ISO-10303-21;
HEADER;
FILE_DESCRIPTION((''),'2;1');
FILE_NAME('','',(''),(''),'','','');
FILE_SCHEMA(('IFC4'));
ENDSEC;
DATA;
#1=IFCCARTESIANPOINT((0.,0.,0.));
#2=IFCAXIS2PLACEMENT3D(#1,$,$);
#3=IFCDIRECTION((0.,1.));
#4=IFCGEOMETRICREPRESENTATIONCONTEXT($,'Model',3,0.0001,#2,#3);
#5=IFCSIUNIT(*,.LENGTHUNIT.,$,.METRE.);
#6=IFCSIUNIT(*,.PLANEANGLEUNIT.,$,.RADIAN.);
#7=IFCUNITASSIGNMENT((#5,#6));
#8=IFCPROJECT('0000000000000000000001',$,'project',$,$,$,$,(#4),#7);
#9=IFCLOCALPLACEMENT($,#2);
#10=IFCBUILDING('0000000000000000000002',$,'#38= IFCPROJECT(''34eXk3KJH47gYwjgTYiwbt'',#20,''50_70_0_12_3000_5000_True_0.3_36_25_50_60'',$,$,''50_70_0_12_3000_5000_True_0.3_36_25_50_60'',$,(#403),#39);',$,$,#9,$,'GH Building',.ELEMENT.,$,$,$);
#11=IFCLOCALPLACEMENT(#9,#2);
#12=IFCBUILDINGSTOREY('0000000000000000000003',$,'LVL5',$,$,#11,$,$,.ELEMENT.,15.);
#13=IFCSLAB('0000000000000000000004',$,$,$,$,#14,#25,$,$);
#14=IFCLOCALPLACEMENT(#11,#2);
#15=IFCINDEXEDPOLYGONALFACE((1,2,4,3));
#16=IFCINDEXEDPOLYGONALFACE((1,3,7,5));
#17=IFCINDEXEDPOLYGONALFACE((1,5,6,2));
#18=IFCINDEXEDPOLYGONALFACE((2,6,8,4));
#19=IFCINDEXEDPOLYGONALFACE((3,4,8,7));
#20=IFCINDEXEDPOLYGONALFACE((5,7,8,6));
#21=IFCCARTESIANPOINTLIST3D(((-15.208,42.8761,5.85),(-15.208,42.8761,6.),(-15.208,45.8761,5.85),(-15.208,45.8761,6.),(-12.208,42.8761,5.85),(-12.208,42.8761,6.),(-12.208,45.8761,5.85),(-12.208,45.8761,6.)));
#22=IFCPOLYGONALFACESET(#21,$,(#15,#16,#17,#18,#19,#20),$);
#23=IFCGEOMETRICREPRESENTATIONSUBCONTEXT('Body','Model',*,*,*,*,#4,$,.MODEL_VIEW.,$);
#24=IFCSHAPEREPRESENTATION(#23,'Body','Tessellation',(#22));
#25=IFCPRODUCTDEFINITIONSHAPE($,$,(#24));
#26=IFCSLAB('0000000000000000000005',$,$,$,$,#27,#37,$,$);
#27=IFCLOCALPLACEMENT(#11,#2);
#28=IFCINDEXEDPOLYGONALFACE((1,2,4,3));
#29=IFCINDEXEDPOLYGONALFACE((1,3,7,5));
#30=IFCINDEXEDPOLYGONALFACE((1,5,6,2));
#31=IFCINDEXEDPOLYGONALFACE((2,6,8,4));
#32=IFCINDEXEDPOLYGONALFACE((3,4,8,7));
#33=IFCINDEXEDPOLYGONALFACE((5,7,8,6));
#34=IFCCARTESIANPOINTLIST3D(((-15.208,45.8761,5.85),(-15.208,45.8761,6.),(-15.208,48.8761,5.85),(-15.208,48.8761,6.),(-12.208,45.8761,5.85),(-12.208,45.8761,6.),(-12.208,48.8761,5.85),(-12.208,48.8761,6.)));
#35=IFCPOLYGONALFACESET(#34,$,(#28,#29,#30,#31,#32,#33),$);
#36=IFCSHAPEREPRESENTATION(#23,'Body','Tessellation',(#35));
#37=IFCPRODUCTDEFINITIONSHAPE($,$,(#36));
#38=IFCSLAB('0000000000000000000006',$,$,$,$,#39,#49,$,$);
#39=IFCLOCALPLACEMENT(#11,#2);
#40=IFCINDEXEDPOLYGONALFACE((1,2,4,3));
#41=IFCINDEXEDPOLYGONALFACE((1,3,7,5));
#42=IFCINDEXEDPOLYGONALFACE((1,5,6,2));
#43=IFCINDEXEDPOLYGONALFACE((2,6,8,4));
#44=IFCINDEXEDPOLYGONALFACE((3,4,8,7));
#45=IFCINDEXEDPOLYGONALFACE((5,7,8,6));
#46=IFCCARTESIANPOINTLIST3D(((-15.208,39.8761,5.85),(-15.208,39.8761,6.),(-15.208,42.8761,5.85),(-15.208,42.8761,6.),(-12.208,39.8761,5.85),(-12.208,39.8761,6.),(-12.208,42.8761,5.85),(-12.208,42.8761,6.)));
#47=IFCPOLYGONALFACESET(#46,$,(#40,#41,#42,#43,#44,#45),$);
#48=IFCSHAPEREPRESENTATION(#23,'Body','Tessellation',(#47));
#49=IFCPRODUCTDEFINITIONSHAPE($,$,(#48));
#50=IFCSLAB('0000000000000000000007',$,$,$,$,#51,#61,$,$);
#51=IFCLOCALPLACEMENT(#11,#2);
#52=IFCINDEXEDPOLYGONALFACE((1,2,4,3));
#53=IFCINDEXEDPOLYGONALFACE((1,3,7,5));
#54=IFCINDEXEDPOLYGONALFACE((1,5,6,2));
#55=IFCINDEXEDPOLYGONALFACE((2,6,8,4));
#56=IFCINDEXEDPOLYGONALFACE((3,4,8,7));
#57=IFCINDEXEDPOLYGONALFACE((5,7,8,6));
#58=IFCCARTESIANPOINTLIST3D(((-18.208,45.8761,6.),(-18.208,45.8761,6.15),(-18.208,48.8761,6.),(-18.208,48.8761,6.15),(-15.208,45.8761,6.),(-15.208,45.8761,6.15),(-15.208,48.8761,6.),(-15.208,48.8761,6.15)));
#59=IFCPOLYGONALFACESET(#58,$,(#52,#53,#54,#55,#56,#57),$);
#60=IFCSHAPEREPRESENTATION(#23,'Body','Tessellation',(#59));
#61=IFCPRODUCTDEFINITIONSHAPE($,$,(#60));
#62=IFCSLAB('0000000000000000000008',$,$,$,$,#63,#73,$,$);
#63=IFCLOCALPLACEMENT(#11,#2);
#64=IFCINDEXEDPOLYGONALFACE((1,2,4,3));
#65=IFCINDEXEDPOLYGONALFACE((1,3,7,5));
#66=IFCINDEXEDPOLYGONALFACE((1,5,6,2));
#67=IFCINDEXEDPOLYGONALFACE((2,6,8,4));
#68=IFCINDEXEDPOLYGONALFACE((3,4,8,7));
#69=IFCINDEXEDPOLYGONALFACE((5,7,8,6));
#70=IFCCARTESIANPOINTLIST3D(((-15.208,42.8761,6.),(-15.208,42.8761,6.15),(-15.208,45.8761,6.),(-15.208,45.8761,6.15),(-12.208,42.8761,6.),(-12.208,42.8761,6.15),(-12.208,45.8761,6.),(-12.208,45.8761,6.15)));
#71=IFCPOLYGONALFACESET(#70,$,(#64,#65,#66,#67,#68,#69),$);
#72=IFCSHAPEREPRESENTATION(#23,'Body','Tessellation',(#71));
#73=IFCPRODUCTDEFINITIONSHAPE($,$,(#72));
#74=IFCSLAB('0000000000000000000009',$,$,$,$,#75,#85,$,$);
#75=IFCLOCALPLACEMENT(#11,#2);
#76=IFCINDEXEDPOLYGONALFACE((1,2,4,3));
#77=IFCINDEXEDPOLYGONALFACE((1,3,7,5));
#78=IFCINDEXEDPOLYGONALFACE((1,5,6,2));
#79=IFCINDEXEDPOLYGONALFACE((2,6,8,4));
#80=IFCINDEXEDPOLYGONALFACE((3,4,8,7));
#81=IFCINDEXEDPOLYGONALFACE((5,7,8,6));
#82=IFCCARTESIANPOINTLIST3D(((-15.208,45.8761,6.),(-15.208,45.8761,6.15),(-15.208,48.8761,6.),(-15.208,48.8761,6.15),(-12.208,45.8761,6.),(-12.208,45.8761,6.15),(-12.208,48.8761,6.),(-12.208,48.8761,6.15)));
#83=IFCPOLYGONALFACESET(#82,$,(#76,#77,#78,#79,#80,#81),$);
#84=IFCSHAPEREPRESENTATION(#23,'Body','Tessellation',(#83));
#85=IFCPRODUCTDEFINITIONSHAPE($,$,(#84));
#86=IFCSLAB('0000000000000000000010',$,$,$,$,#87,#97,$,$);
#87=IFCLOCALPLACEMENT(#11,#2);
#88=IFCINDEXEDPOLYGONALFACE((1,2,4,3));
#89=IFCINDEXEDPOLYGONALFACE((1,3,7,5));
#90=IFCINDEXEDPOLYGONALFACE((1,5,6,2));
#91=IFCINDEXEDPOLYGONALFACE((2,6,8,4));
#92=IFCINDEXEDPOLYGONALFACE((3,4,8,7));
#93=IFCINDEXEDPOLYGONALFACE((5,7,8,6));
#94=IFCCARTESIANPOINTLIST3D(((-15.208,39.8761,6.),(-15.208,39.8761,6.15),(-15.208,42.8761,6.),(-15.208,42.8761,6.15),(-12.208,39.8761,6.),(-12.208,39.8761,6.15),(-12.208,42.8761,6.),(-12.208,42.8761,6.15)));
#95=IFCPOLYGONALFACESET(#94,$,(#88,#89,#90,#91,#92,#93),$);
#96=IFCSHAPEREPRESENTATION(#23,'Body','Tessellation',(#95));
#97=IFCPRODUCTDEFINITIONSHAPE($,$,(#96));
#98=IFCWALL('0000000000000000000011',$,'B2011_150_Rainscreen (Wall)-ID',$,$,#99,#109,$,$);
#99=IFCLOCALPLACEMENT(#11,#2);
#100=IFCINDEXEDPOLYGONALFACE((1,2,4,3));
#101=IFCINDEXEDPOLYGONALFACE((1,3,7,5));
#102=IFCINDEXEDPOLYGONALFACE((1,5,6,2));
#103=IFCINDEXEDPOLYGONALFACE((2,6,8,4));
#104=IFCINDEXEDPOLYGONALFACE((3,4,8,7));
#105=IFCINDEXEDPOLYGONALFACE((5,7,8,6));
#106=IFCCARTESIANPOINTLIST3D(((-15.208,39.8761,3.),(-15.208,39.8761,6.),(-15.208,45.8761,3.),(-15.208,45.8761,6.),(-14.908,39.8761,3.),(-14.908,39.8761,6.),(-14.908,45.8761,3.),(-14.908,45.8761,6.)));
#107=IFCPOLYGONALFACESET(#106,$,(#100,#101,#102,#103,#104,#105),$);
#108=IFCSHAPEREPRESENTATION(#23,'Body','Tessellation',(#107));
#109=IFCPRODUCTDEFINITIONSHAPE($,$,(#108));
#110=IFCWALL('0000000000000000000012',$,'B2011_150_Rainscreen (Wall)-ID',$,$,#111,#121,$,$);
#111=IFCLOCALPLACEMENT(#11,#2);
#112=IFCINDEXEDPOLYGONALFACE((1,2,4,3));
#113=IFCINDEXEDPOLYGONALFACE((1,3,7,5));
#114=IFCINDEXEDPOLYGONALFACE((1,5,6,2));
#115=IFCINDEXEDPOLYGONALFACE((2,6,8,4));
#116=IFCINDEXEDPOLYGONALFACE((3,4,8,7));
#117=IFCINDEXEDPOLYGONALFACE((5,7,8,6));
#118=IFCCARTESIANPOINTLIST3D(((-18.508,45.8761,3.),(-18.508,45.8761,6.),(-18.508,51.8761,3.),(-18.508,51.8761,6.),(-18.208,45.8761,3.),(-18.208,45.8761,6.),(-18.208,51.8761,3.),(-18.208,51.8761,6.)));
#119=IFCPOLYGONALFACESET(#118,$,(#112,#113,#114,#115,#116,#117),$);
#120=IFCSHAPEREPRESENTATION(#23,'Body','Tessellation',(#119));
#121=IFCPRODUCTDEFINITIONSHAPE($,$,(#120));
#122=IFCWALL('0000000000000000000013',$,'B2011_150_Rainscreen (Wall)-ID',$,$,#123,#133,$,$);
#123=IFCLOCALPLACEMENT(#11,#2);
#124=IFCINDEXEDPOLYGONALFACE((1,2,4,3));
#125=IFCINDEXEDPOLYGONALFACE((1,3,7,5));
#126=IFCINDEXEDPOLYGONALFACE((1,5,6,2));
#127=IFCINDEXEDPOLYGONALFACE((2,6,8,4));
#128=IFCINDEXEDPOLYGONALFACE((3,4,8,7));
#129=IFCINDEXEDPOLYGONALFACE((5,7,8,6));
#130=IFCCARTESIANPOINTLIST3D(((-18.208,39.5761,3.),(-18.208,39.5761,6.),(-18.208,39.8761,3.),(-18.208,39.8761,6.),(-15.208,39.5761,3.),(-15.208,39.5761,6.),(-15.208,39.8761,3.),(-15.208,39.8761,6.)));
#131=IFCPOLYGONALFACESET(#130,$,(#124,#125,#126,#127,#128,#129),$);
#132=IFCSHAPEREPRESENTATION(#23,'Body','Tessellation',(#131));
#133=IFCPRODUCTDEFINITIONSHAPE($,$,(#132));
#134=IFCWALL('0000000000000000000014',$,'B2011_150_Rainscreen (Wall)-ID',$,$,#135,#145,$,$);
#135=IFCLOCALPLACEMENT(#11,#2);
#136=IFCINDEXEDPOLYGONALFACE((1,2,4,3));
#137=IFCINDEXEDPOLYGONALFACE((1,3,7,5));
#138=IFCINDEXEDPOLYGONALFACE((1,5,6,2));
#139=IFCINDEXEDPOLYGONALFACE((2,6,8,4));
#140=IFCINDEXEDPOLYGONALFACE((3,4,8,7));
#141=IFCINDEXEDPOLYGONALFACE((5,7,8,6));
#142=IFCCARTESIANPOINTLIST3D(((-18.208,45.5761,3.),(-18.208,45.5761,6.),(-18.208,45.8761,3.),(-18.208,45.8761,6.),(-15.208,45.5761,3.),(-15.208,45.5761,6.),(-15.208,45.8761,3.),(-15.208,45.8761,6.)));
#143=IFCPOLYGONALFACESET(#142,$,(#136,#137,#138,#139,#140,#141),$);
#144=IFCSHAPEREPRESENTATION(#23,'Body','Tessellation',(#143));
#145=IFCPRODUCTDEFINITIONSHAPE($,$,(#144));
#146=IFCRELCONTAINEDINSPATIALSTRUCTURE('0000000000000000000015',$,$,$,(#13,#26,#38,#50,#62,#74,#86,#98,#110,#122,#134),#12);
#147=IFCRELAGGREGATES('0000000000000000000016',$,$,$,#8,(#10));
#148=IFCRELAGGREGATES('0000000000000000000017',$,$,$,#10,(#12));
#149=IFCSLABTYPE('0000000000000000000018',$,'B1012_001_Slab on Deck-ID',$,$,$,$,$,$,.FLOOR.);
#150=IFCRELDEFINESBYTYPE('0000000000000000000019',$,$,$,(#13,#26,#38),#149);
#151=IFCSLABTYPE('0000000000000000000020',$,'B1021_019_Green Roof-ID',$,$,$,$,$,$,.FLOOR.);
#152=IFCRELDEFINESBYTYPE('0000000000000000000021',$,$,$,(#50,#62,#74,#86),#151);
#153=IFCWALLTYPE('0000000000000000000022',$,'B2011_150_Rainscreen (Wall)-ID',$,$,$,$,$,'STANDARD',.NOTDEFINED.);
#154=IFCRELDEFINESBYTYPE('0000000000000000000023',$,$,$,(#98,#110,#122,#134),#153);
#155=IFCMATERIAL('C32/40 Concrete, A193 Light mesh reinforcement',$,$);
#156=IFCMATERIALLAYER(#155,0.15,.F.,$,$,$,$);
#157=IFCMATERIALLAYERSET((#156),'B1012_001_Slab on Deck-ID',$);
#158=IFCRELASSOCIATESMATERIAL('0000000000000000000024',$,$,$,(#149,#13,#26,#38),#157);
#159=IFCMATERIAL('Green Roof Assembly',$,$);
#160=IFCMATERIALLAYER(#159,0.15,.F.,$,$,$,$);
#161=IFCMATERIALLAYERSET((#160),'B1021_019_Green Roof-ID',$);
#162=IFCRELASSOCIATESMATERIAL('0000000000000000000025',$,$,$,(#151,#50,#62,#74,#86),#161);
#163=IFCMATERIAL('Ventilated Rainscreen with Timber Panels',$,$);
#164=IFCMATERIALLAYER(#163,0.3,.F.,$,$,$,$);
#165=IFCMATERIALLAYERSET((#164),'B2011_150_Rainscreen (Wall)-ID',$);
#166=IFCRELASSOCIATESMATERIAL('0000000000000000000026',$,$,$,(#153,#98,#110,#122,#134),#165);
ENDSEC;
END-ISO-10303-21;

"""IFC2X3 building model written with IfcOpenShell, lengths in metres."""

from ifc_helpers import new_model, si_unit, direction, frame, frame_2d, origin, place, context, subcontext, project, spatial, polyline, rectangle, outline, extrude, material, layer, layer_set, layer_usage, type_object, element, save


model = new_model("IFC2X3")

# Units and contexts
model_context = context("Model", 3, precision=0.0001, world=origin(), true_north=direction((0.0, 1.0)))
body_context = subcontext(model_context, "Body", "Model", "MODEL_VIEW")
ifc_project = project(units=[si_unit("LENGTHUNIT", "METRE"), si_unit("PLANEANGLEUNIT", "RADIAN")], contexts=[model_context])

# Building, storey
building_placement = place(None, origin())
building = spatial("IfcBuilding", under=ifc_project, at=building_placement, Name="#38= IFCPROJECT('34eXk3KJH47gYwjgTYiwbt',#20,'50_70_0_12_3000_5000_True_0.3_36_25_50_60',$,$,'50_70_0_12_3000_5000_True_0.3_36_25_50_60',$,(#403),#39);", LongName="GH Building", CompositionType="ELEMENT")
storey_placement = place(building_placement, origin())
storey = spatial("IfcBuildingStorey", under=building, at=storey_placement, Name="LVL5", CompositionType="ELEMENT", Elevation=15.0)

# Slabs
ifc_material_1 = material(Name="C32/40 Concrete, A193 Light mesh reinforcement")
ifc_layer_1 = layer(ifc_material_1, 0.15, ventilated=False)
ifc_layer_set_1 = layer_set([ifc_layer_1], Name="B1012_001_Slab on Deck-ID")
slab_type_1 = type_object("IfcSlabType", Name="B1012_001_Slab on Deck-ID", PredefinedType="FLOOR", material=ifc_layer_set_1)
ifc_layer_usage_1 = layer_usage(ifc_layer_set_1, "AXIS3", "NEGATIVE", -0.15)
slab_1_placement = place(storey_placement, frame((-13.708, 44.3761, 5.85)))
element("IfcSlab", 1, at=slab_1_placement, inside=storey, type_object=slab_type_1, material=ifc_layer_usage_1, context=body_context, shape_type="SweptSolid", body=[
    extrude(outline(polyline([(-1.5, -1.5), (-1.5, 1.5), (1.5, 1.5), (1.5, -1.5), (-1.5, -1.5)])), origin(), (0.0, 0.0, 1.0), 0.15),
])
ifc_layer_usage_2 = layer_usage(ifc_layer_set_1, "AXIS3", "NEGATIVE", -0.15)
slab_2_placement = place(storey_placement, frame((-13.708, 47.3761, 5.85)))
element("IfcSlab", 2, at=slab_2_placement, inside=storey, type_object=slab_type_1, material=ifc_layer_usage_2, context=body_context, shape_type="SweptSolid", body=[
    extrude(outline(polyline([(-1.5, 1.5), (1.5, 1.5), (1.5, -1.5), (-1.5, -1.5), (-1.5, 1.5)])), origin(), (0.0, 0.0, 1.0), 0.15),
])
ifc_layer_usage_3 = layer_usage(ifc_layer_set_1, "AXIS3", "NEGATIVE", -0.15)
slab_3_placement = place(storey_placement, frame((-13.708, 41.3761, 5.85)))
element("IfcSlab", 3, at=slab_3_placement, inside=storey, type_object=slab_type_1, material=ifc_layer_usage_3, context=body_context, shape_type="SweptSolid", body=[
    extrude(outline(polyline([(1.5, 1.5), (1.5, -1.5), (-1.5, -1.5), (-1.5, 1.5), (1.5, 1.5)])), origin(), (0.0, 0.0, 1.0), 0.15),
])
ifc_material_2 = material(Name="Green Roof Assembly")
ifc_layer_2 = layer(ifc_material_2, 0.15, ventilated=False)
ifc_layer_set_2 = layer_set([ifc_layer_2], Name="B1021_019_Green Roof-ID")
ifc_layer_usage_4 = layer_usage(ifc_layer_set_2, "AXIS3", "NEGATIVE", -0.15)
slab_type_2 = type_object("IfcSlabType", Name="B1021_019_Green Roof-ID", PredefinedType="FLOOR", material=ifc_layer_set_2)
slab_4_placement = place(storey_placement, frame((-16.708, 47.3761, 6.0)))
element("IfcSlab", 4, at=slab_4_placement, inside=storey, type_object=slab_type_2, material=ifc_layer_usage_4, context=body_context, shape_type="SweptSolid", body=[
    extrude(outline(polyline([(-1.5, 1.5), (1.5, 1.5), (1.5, -1.5), (-1.5, -1.5), (-1.5, 1.5)])), origin(), (0.0, 0.0, 1.0), 0.15),
])
ifc_layer_usage_5 = layer_usage(ifc_layer_set_2, "AXIS3", "NEGATIVE", -0.15)
slab_5_placement = place(storey_placement, frame((-13.708, 44.3761, 6.0)))
element("IfcSlab", 5, at=slab_5_placement, inside=storey, type_object=slab_type_2, material=ifc_layer_usage_5, context=body_context, shape_type="SweptSolid", body=[
    extrude(outline(polyline([(-1.5, -1.5), (-1.5, 1.5), (1.5, 1.5), (1.5, -1.5), (-1.5, -1.5)])), origin(), (0.0, 0.0, 1.0), 0.15),
])
ifc_layer_usage_6 = layer_usage(ifc_layer_set_2, "AXIS3", "NEGATIVE", -0.15)
slab_6_placement = place(storey_placement, frame((-13.708, 47.3761, 6.0)))
element("IfcSlab", 6, at=slab_6_placement, inside=storey, type_object=slab_type_2, material=ifc_layer_usage_6, context=body_context, shape_type="SweptSolid", body=[
    extrude(outline(polyline([(-1.5, 1.5), (1.5, 1.5), (1.5, -1.5), (-1.5, -1.5), (-1.5, 1.5)])), origin(), (0.0, 0.0, 1.0), 0.15),
])
ifc_layer_usage_7 = layer_usage(ifc_layer_set_2, "AXIS3", "NEGATIVE", -0.15)
slab_7_placement = place(storey_placement, frame((-13.708, 41.3761, 6.0)))
element("IfcSlab", 7, at=slab_7_placement, inside=storey, type_object=slab_type_2, material=ifc_layer_usage_7, context=body_context, shape_type="SweptSolid", body=[
    extrude(outline(polyline([(1.5, 1.5), (1.5, -1.5), (-1.5, -1.5), (-1.5, 1.5), (1.5, 1.5)])), origin(), (0.0, 0.0, 1.0), 0.15),
])

# Walls
ifc_material_3 = material(Name="Ventilated Rainscreen with Timber Panels")
ifc_layer_3 = layer(ifc_material_3, 0.3, ventilated=False)
ifc_layer_set_3 = layer_set([ifc_layer_3], Name="B2011_150_Rainscreen (Wall)-ID")
ifc_layer_usage_8 = layer_usage(ifc_layer_set_3, "AXIS2", "POSITIVE", 0.0)
wall_type = type_object("IfcWallType", Name="B2011_150_Rainscreen (Wall)-ID", ElementType="STANDARD", PredefinedType="NOTDEFINED", material=ifc_layer_set_3)
wall_1_placement = place(storey_placement, frame((-15.208, 45.8761, 3.0), z_axis=(0.0, 0.0, 1.0), x_axis=(0.0, -1.0, 0.0)))
element("IfcWall", 8, at=wall_1_placement, inside=storey, type_object=wall_type, material=ifc_layer_usage_8, Name="B2011_150_Rainscreen (Wall)-ID", context=body_context, shape_type="SweptSolid", body=[
    extrude(rectangle(XDim=6.0, YDim=0.3, at=frame_2d((3.0, 0.15))), origin(), (0.0, 0.0, 1.0), 3.0),
])
ifc_layer_usage_9 = layer_usage(ifc_layer_set_3, "AXIS2", "POSITIVE", 0.0)
wall_2_placement = place(storey_placement, frame((-18.208, 45.8761, 3.0), z_axis=(0.0, 0.0, 1.0), x_axis=(0.0, 1.0, 0.0)))
element("IfcWall", 9, at=wall_2_placement, inside=storey, type_object=wall_type, material=ifc_layer_usage_9, Name="B2011_150_Rainscreen (Wall)-ID", context=body_context, shape_type="SweptSolid", body=[
    extrude(rectangle(XDim=6.0, YDim=0.3, at=frame_2d((3.0, 0.15))), origin(), (0.0, 0.0, 1.0), 3.0),
])
ifc_layer_usage_10 = layer_usage(ifc_layer_set_3, "AXIS2", "POSITIVE", 0.0)
wall_3_placement = place(storey_placement, frame((-15.208, 39.8761, 3.0), z_axis=(0.0, 0.0, 1.0), x_axis=(-1.0, 0.0, 0.0)))
element("IfcWall", 10, at=wall_3_placement, inside=storey, type_object=wall_type, material=ifc_layer_usage_10, Name="B2011_150_Rainscreen (Wall)-ID", context=body_context, shape_type="SweptSolid", body=[
    extrude(rectangle(XDim=3.0, YDim=0.3, at=frame_2d((1.5, 0.15))), origin(), (0.0, 0.0, 1.0), 3.0),
])
ifc_layer_usage_11 = layer_usage(ifc_layer_set_3, "AXIS2", "POSITIVE", 0.0)
wall_4_placement = place(storey_placement, frame((-15.208, 45.8761, 3.0), z_axis=(0.0, 0.0, 1.0), x_axis=(-1.0, 0.0, 0.0)))
element("IfcWall", 11, at=wall_4_placement, inside=storey, type_object=wall_type, material=ifc_layer_usage_11, Name="B2011_150_Rainscreen (Wall)-ID", context=body_context, shape_type="SweptSolid", body=[
    extrude(rectangle(XDim=3.0, YDim=0.3, at=frame_2d((1.5, 0.15))), origin(), (0.0, 0.0, 1.0), 3.0),
])

save(model, "model.ifc")
